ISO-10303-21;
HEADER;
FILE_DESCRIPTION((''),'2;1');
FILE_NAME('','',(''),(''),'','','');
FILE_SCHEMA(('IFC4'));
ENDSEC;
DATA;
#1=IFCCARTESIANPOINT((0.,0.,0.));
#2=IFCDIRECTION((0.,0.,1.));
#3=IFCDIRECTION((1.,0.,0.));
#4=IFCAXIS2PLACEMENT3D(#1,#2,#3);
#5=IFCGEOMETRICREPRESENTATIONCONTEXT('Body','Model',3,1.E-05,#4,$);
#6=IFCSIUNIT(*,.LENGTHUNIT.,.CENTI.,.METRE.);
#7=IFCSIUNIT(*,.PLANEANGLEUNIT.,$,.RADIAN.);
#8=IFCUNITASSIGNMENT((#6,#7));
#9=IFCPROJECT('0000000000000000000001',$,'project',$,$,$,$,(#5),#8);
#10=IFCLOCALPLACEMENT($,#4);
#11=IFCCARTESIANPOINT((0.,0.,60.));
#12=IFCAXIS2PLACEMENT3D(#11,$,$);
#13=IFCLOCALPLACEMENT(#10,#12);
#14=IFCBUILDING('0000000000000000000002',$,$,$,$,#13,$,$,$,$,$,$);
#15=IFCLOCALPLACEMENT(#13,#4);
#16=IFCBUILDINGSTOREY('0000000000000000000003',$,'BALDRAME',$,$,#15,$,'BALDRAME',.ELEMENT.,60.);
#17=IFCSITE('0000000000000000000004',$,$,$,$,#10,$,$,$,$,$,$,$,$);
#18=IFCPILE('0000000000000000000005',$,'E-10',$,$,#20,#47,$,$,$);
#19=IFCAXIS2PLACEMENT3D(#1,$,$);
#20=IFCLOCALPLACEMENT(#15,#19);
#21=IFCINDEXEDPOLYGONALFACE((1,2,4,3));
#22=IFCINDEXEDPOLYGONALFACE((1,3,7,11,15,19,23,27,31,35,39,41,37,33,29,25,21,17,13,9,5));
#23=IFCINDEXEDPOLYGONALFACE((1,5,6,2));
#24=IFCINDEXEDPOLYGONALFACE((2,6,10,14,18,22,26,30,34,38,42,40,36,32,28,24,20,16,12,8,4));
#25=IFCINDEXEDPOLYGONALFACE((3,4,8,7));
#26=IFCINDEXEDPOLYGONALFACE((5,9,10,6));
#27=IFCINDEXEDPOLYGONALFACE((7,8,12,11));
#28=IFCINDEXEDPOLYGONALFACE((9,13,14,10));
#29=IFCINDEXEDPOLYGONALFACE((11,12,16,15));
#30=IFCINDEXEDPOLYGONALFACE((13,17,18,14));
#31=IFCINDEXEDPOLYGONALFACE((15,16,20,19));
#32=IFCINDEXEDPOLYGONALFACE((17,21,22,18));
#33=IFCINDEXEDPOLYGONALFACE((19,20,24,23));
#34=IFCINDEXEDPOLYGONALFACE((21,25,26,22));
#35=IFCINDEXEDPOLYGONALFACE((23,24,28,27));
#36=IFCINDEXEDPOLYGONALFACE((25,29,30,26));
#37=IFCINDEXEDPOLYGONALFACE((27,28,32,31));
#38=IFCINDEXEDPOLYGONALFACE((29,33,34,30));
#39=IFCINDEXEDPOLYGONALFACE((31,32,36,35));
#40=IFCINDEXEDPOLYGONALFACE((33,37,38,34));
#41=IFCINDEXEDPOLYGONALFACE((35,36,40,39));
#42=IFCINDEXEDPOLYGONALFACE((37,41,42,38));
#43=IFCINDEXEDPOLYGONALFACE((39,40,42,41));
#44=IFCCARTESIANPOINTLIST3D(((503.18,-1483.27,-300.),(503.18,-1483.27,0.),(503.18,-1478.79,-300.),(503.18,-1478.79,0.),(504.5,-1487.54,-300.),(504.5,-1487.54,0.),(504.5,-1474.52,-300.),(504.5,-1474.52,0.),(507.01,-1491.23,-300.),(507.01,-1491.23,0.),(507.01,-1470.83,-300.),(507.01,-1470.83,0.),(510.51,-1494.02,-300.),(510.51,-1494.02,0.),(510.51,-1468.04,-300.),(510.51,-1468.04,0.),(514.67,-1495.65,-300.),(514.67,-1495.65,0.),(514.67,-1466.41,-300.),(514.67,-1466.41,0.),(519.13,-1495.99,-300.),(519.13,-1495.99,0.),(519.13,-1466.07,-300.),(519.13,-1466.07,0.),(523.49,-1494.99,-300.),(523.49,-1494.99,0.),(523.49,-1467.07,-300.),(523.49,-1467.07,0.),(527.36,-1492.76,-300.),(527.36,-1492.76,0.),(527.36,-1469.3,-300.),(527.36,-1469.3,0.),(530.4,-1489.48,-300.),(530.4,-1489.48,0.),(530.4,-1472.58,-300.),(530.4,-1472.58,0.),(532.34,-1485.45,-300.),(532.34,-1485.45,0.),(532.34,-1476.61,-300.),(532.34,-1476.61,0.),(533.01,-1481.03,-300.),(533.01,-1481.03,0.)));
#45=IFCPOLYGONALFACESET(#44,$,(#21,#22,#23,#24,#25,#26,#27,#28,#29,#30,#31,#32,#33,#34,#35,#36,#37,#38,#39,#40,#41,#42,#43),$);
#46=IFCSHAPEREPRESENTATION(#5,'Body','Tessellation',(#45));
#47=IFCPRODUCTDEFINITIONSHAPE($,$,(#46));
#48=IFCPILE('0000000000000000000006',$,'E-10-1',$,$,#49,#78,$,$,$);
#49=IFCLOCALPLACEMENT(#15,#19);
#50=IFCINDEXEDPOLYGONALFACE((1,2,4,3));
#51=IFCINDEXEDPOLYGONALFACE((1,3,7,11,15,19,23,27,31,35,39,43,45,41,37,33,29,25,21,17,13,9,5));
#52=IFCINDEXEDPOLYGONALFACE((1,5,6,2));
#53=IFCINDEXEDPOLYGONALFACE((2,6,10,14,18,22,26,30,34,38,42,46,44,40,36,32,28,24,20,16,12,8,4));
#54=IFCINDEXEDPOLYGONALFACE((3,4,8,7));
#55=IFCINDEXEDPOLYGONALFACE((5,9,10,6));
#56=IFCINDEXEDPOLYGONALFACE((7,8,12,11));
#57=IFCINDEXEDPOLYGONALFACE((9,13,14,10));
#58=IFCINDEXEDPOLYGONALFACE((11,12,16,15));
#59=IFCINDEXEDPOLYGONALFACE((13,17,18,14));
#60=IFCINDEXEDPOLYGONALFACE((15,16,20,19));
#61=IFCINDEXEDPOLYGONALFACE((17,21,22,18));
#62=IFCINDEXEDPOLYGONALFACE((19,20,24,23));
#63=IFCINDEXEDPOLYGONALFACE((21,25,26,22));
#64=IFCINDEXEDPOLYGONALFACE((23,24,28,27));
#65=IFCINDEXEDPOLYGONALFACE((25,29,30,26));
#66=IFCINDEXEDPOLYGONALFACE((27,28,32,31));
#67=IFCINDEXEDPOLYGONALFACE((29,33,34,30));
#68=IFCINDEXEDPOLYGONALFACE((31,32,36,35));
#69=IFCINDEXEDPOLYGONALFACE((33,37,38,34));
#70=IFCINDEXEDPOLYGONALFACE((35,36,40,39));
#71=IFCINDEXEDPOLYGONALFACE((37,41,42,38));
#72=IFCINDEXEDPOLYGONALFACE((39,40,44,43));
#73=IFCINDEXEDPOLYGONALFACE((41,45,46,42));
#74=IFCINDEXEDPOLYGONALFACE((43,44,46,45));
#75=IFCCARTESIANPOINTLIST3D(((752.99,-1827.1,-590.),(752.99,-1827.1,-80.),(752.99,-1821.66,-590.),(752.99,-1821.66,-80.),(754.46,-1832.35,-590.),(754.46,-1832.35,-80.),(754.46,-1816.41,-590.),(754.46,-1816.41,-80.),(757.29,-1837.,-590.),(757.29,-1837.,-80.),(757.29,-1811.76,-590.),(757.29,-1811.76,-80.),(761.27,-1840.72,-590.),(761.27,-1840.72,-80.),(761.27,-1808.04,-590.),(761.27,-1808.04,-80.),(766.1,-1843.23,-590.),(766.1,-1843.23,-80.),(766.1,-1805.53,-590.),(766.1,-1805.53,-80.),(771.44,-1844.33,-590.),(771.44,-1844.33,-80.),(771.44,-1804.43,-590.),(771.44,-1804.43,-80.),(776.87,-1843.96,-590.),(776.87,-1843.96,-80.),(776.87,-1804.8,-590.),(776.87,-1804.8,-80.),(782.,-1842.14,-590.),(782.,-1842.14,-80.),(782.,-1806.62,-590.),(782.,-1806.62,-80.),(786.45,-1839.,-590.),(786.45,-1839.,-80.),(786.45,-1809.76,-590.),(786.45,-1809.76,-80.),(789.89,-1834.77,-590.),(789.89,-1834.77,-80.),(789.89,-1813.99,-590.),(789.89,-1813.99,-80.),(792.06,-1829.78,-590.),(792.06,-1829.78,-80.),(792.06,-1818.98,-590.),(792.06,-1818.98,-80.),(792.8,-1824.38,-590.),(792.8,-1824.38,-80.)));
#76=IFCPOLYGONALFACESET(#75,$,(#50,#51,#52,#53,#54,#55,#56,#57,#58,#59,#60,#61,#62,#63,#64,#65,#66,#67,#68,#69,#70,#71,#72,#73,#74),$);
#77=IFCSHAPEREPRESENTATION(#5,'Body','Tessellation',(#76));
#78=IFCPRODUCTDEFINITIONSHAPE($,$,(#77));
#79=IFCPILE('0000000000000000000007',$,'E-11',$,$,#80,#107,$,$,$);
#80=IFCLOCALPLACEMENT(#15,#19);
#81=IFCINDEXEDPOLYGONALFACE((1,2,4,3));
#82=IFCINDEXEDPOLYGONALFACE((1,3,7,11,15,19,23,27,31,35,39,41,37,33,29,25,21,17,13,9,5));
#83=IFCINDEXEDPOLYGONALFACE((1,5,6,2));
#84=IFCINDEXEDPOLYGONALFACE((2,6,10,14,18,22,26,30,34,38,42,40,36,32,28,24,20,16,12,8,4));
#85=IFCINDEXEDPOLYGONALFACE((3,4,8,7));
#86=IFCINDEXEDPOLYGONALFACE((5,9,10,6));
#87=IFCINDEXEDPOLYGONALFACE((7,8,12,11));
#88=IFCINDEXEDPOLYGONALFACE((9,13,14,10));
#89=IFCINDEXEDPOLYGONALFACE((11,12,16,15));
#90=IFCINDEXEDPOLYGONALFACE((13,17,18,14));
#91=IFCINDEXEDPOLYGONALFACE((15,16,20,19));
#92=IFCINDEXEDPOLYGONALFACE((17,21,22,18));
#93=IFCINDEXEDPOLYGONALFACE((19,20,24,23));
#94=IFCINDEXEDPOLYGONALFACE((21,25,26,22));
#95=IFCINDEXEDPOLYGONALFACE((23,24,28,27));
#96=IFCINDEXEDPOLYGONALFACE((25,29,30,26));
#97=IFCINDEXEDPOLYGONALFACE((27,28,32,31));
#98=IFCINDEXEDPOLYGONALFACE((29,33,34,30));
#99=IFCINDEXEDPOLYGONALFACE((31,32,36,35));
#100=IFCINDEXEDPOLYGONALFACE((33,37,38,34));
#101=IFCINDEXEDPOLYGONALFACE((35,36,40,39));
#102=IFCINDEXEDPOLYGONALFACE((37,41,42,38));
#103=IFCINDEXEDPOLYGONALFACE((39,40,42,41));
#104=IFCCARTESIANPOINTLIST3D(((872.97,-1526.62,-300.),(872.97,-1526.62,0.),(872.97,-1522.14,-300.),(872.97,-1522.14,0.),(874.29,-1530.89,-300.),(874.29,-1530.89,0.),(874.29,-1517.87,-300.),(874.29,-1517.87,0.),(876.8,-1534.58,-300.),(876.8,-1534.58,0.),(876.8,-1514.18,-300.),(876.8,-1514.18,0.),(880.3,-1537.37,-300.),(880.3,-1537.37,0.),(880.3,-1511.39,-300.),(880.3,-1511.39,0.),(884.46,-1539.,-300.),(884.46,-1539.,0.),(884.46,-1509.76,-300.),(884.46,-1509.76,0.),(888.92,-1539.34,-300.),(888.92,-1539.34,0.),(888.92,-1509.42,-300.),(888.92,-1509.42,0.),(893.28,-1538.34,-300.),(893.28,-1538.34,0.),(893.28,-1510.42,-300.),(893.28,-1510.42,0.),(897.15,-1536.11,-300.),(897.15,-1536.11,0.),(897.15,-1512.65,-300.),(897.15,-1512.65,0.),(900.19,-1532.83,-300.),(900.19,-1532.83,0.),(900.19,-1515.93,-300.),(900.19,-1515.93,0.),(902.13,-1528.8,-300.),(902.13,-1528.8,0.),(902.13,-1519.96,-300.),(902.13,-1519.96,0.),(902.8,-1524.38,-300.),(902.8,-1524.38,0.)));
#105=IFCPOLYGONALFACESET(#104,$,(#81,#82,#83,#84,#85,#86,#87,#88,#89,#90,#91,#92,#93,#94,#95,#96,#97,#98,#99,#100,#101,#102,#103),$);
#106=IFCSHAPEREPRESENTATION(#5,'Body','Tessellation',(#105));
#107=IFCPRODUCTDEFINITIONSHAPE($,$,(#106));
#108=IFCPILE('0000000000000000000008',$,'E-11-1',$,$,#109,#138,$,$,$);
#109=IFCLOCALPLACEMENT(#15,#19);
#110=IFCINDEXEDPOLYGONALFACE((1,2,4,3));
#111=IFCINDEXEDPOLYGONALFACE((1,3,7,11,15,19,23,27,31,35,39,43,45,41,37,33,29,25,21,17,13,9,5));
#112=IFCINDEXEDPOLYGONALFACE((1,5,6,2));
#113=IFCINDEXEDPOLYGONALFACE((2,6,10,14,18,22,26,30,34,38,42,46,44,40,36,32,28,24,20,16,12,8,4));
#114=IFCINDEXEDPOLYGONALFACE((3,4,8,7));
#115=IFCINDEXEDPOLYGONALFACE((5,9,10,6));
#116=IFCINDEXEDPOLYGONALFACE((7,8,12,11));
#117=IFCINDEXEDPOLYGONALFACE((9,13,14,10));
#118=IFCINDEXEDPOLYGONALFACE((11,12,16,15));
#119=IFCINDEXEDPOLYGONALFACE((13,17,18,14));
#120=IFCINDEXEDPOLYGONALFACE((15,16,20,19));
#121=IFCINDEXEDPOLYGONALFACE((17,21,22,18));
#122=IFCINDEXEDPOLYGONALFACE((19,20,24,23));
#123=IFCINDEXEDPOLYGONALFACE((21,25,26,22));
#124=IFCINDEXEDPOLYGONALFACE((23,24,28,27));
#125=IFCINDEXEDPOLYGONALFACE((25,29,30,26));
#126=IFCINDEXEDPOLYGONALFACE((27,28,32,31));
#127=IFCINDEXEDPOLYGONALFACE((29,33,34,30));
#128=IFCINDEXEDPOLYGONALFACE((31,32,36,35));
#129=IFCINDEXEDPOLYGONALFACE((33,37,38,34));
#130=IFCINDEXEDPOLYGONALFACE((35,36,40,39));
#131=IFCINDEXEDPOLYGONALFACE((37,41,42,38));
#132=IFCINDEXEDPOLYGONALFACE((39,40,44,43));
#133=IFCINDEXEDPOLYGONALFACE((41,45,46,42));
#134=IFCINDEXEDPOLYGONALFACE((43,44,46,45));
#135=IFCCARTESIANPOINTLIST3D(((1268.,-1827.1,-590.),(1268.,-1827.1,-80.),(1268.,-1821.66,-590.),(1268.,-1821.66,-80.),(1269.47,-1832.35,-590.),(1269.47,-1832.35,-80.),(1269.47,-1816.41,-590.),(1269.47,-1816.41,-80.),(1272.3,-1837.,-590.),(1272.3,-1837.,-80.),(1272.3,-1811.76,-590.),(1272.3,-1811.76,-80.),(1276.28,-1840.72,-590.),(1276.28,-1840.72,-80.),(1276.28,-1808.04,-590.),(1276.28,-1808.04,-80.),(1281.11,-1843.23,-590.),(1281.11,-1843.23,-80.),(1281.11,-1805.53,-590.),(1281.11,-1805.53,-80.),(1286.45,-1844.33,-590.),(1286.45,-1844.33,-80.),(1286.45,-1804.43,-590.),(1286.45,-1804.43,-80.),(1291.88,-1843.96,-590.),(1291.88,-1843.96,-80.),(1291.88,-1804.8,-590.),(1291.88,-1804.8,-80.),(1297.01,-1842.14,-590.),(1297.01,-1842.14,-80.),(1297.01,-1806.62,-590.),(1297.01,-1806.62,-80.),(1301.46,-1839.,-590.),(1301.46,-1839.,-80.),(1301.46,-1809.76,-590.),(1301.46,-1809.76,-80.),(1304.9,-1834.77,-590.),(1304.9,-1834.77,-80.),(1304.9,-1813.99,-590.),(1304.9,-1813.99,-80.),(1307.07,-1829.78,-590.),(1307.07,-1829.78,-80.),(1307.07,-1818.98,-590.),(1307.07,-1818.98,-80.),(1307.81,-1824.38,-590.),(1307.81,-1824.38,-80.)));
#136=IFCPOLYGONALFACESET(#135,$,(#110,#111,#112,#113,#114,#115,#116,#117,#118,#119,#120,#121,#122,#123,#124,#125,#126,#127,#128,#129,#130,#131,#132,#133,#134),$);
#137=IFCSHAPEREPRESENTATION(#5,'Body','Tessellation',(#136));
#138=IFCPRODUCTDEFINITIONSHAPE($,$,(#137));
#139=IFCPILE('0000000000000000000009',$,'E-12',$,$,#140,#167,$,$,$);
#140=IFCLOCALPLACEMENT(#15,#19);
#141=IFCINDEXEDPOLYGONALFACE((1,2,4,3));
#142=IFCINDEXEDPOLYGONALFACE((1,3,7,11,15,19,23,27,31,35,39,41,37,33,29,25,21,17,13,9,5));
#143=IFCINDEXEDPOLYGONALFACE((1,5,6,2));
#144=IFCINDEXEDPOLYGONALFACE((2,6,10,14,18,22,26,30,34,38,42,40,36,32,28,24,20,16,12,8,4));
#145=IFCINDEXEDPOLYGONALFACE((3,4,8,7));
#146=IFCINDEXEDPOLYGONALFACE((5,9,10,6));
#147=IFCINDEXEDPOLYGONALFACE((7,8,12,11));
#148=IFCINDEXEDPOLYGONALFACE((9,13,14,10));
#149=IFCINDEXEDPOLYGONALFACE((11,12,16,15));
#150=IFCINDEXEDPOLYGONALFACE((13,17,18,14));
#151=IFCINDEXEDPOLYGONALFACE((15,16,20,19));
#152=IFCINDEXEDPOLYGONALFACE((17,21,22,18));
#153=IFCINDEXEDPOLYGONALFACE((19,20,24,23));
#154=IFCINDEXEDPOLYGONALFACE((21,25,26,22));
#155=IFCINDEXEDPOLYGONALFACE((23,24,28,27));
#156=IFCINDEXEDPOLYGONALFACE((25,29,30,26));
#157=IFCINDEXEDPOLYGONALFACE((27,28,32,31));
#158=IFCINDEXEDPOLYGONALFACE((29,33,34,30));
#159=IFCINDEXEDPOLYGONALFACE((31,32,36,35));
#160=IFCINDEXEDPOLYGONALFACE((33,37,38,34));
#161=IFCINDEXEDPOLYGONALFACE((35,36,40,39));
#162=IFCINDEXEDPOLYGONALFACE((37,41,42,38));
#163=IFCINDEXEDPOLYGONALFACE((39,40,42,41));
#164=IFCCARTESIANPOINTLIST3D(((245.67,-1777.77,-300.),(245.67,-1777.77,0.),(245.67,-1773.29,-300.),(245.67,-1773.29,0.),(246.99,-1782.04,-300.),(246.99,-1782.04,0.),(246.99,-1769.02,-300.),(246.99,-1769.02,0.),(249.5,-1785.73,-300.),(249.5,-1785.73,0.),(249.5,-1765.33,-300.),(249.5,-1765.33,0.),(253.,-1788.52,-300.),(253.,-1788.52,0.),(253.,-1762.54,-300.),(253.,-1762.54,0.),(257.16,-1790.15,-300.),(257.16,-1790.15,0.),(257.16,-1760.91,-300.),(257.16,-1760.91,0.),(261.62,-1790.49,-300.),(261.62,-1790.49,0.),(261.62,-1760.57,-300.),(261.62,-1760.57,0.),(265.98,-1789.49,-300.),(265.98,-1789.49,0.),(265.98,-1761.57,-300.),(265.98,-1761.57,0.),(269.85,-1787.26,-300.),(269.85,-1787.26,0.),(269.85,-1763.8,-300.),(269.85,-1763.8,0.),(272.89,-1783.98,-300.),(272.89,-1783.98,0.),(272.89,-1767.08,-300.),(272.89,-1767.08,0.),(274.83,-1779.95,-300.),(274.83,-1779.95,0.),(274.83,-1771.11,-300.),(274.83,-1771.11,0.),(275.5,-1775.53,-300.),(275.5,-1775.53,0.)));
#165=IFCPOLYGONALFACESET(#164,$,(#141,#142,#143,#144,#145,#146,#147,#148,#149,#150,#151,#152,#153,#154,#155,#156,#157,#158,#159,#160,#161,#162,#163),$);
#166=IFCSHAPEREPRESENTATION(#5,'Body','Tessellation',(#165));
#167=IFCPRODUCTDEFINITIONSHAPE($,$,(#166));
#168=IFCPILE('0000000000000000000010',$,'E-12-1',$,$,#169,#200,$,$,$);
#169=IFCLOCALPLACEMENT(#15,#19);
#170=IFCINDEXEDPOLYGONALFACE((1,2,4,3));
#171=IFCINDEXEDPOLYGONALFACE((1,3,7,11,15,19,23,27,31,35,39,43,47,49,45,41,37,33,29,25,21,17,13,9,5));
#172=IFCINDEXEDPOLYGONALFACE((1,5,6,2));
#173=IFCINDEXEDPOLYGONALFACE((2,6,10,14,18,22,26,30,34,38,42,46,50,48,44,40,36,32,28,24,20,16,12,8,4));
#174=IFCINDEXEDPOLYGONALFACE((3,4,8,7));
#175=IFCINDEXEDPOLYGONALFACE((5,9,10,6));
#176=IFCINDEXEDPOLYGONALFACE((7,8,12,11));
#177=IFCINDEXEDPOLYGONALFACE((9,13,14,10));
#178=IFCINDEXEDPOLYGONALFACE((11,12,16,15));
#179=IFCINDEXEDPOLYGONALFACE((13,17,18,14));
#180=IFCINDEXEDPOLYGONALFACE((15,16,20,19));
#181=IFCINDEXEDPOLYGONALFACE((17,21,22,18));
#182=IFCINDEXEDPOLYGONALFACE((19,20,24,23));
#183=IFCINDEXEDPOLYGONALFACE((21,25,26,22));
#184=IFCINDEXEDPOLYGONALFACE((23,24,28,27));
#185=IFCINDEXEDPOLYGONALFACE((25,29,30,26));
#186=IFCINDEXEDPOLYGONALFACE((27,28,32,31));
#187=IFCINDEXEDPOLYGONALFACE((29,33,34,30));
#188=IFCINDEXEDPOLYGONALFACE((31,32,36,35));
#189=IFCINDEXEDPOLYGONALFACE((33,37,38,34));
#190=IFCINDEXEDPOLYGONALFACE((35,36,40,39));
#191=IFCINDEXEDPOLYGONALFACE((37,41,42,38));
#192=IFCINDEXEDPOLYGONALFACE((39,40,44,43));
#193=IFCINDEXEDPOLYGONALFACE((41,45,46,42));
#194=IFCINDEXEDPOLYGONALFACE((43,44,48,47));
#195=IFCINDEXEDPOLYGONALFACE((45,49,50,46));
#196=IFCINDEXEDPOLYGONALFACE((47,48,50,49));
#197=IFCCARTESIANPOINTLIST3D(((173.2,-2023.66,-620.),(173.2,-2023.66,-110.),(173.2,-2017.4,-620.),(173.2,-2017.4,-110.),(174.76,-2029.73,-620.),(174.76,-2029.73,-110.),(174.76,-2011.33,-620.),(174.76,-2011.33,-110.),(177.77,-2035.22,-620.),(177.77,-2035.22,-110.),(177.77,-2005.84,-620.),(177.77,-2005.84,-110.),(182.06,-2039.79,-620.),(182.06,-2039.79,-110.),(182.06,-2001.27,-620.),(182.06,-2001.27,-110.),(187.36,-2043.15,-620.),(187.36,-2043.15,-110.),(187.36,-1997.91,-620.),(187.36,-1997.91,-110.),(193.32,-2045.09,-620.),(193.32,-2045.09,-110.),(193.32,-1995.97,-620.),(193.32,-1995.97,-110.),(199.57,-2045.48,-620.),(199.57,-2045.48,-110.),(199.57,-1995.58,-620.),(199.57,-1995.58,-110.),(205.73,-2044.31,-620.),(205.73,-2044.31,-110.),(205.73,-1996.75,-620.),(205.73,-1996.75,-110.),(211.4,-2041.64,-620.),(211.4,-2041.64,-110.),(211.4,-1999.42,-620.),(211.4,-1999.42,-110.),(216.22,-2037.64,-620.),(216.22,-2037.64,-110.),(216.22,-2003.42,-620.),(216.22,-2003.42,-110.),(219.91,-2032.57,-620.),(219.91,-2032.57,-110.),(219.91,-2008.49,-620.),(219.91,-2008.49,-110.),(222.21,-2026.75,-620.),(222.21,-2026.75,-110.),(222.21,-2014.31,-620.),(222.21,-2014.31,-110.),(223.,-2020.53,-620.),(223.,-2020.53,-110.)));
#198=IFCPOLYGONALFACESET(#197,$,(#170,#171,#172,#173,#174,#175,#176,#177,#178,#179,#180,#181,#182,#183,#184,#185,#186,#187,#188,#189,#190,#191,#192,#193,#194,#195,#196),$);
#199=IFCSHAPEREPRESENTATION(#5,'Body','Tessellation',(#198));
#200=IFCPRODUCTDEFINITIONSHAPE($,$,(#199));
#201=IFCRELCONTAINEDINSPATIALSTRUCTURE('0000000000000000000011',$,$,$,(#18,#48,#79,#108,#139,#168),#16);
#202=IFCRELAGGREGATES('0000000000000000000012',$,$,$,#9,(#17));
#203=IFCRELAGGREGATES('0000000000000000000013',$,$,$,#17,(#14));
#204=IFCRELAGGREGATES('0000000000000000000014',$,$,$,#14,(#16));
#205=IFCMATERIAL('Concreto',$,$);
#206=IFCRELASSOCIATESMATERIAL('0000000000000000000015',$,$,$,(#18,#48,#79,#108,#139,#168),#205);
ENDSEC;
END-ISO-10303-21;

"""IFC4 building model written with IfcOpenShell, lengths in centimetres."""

from ifc_helpers import new_model, si_unit, frame, origin_with_axes, origin_2d_with_axis, place, context, project, spatial, circle, extrude, material, element, save


model = new_model("IFC4")

# Units and contexts
model_context = context("Model", 3, precision=1e-05, world=origin_with_axes(), identifier="Body")
ifc_project = project(units=[si_unit("LENGTHUNIT", "METRE", prefix="CENTI"), si_unit("PLANEANGLEUNIT", "RADIAN")], contexts=[model_context])

# Site, building, storey
site_placement = place(None, origin_with_axes())
site = spatial("IfcSite", under=ifc_project, at=site_placement)
building_placement = place(site_placement, frame((0.0, 0.0, 60.0)))
building = spatial("IfcBuilding", under=site, at=building_placement)
storey_placement = place(building_placement, origin_with_axes())
storey = spatial("IfcBuildingStorey", under=building, at=storey_placement, Name="BALDRAME", LongName="BALDRAME", CompositionType="ELEMENT", Elevation=60.0)

# Piles
ifc_material = material(Name="Concreto")
pile_1_placement = place(storey_placement, frame((518.01, -1481.03, 0.0), z_axis=(0.0, 0.0, 1.0), x_axis=(1.0, 0.0, 0.0)))
element("IfcPile", 1, at=pile_1_placement, inside=storey, material=ifc_material, Name="E-10", context=model_context, shape_type="SolidModel", body=[
    extrude(circle(Radius=15.0, at=origin_2d_with_axis()), frame((0.0, 0.0, -300.0), z_axis=(0.0, 0.0, 1.0), x_axis=(1.0, 0.0, 0.0)), (0.0, 0.0, 1.0), 300.0),
])
pile_2_placement = place(storey_placement, frame((772.8, -1824.38, -80.0), z_axis=(0.0, 0.0, 1.0), x_axis=(1.0, 0.0, 0.0)))
element("IfcPile", 2, at=pile_2_placement, inside=storey, material=ifc_material, Name="E-10-1", context=model_context, shape_type="SweptSolid", body=[
    extrude(circle(Radius=20.0, at=origin_2d_with_axis()), frame((0.0, 0.0, -510.0), z_axis=(0.0, 0.0, 1.0), x_axis=(1.0, 0.0, 0.0)), (0.0, 0.0, 1.0), 510.0),
])
pile_3_placement = place(storey_placement, frame((887.8, -1524.38, 0.0), z_axis=(0.0, 0.0, 1.0), x_axis=(1.0, 0.0, 0.0)))
element("IfcPile", 3, at=pile_3_placement, inside=storey, material=ifc_material, Name="E-11", context=model_context, shape_type="SolidModel", body=[
    extrude(circle(Radius=15.0, at=origin_2d_with_axis()), frame((0.0, 0.0, -300.0), z_axis=(0.0, 0.0, 1.0), x_axis=(1.0, 0.0, 0.0)), (0.0, 0.0, 1.0), 300.0),
])
pile_4_placement = place(storey_placement, frame((1287.81, -1824.38, -80.0), z_axis=(0.0, 0.0, 1.0), x_axis=(1.0, 0.0, 0.0)))
element("IfcPile", 4, at=pile_4_placement, inside=storey, material=ifc_material, Name="E-11-1", context=model_context, shape_type="SweptSolid", body=[
    extrude(circle(Radius=20.0, at=origin_2d_with_axis()), frame((0.0, 0.0, -510.0), z_axis=(0.0, 0.0, 1.0), x_axis=(1.0, 0.0, 0.0)), (0.0, 0.0, 1.0), 510.0),
])
pile_5_placement = place(storey_placement, frame((260.5, -1775.53, 0.0), z_axis=(0.0, 0.0, 1.0), x_axis=(1.0, 0.0, 0.0)))
element("IfcPile", 5, at=pile_5_placement, inside=storey, material=ifc_material, Name="E-12", context=model_context, shape_type="SolidModel", body=[
    extrude(circle(Radius=15.0, at=origin_2d_with_axis()), frame((0.0, 0.0, -300.0), z_axis=(0.0, 0.0, 1.0), x_axis=(1.0, 0.0, 0.0)), (0.0, 0.0, 1.0), 300.0),
])
for number, where, z_axis, x_axis, name in (
    (6, (198.0, -2020.53, -110.0), (0.0, 0.0, 1.0), (1.0, 0.0, 0.0), "E-12-1"),
):
    element("IfcPile", number, at=place(storey_placement, frame(where, z_axis=z_axis, x_axis=x_axis)), inside=storey, material=ifc_material, Name=name, context=model_context, shape_type="SweptSolid", body=[
        extrude(circle(Radius=25.0, at=origin_2d_with_axis()), frame((0.0, 0.0, -510.0), z_axis=(0.0, 0.0, 1.0), x_axis=(1.0, 0.0, 0.0)), (0.0, 0.0, 1.0), 510.0),
    ])

save(model, "model.ifc")
